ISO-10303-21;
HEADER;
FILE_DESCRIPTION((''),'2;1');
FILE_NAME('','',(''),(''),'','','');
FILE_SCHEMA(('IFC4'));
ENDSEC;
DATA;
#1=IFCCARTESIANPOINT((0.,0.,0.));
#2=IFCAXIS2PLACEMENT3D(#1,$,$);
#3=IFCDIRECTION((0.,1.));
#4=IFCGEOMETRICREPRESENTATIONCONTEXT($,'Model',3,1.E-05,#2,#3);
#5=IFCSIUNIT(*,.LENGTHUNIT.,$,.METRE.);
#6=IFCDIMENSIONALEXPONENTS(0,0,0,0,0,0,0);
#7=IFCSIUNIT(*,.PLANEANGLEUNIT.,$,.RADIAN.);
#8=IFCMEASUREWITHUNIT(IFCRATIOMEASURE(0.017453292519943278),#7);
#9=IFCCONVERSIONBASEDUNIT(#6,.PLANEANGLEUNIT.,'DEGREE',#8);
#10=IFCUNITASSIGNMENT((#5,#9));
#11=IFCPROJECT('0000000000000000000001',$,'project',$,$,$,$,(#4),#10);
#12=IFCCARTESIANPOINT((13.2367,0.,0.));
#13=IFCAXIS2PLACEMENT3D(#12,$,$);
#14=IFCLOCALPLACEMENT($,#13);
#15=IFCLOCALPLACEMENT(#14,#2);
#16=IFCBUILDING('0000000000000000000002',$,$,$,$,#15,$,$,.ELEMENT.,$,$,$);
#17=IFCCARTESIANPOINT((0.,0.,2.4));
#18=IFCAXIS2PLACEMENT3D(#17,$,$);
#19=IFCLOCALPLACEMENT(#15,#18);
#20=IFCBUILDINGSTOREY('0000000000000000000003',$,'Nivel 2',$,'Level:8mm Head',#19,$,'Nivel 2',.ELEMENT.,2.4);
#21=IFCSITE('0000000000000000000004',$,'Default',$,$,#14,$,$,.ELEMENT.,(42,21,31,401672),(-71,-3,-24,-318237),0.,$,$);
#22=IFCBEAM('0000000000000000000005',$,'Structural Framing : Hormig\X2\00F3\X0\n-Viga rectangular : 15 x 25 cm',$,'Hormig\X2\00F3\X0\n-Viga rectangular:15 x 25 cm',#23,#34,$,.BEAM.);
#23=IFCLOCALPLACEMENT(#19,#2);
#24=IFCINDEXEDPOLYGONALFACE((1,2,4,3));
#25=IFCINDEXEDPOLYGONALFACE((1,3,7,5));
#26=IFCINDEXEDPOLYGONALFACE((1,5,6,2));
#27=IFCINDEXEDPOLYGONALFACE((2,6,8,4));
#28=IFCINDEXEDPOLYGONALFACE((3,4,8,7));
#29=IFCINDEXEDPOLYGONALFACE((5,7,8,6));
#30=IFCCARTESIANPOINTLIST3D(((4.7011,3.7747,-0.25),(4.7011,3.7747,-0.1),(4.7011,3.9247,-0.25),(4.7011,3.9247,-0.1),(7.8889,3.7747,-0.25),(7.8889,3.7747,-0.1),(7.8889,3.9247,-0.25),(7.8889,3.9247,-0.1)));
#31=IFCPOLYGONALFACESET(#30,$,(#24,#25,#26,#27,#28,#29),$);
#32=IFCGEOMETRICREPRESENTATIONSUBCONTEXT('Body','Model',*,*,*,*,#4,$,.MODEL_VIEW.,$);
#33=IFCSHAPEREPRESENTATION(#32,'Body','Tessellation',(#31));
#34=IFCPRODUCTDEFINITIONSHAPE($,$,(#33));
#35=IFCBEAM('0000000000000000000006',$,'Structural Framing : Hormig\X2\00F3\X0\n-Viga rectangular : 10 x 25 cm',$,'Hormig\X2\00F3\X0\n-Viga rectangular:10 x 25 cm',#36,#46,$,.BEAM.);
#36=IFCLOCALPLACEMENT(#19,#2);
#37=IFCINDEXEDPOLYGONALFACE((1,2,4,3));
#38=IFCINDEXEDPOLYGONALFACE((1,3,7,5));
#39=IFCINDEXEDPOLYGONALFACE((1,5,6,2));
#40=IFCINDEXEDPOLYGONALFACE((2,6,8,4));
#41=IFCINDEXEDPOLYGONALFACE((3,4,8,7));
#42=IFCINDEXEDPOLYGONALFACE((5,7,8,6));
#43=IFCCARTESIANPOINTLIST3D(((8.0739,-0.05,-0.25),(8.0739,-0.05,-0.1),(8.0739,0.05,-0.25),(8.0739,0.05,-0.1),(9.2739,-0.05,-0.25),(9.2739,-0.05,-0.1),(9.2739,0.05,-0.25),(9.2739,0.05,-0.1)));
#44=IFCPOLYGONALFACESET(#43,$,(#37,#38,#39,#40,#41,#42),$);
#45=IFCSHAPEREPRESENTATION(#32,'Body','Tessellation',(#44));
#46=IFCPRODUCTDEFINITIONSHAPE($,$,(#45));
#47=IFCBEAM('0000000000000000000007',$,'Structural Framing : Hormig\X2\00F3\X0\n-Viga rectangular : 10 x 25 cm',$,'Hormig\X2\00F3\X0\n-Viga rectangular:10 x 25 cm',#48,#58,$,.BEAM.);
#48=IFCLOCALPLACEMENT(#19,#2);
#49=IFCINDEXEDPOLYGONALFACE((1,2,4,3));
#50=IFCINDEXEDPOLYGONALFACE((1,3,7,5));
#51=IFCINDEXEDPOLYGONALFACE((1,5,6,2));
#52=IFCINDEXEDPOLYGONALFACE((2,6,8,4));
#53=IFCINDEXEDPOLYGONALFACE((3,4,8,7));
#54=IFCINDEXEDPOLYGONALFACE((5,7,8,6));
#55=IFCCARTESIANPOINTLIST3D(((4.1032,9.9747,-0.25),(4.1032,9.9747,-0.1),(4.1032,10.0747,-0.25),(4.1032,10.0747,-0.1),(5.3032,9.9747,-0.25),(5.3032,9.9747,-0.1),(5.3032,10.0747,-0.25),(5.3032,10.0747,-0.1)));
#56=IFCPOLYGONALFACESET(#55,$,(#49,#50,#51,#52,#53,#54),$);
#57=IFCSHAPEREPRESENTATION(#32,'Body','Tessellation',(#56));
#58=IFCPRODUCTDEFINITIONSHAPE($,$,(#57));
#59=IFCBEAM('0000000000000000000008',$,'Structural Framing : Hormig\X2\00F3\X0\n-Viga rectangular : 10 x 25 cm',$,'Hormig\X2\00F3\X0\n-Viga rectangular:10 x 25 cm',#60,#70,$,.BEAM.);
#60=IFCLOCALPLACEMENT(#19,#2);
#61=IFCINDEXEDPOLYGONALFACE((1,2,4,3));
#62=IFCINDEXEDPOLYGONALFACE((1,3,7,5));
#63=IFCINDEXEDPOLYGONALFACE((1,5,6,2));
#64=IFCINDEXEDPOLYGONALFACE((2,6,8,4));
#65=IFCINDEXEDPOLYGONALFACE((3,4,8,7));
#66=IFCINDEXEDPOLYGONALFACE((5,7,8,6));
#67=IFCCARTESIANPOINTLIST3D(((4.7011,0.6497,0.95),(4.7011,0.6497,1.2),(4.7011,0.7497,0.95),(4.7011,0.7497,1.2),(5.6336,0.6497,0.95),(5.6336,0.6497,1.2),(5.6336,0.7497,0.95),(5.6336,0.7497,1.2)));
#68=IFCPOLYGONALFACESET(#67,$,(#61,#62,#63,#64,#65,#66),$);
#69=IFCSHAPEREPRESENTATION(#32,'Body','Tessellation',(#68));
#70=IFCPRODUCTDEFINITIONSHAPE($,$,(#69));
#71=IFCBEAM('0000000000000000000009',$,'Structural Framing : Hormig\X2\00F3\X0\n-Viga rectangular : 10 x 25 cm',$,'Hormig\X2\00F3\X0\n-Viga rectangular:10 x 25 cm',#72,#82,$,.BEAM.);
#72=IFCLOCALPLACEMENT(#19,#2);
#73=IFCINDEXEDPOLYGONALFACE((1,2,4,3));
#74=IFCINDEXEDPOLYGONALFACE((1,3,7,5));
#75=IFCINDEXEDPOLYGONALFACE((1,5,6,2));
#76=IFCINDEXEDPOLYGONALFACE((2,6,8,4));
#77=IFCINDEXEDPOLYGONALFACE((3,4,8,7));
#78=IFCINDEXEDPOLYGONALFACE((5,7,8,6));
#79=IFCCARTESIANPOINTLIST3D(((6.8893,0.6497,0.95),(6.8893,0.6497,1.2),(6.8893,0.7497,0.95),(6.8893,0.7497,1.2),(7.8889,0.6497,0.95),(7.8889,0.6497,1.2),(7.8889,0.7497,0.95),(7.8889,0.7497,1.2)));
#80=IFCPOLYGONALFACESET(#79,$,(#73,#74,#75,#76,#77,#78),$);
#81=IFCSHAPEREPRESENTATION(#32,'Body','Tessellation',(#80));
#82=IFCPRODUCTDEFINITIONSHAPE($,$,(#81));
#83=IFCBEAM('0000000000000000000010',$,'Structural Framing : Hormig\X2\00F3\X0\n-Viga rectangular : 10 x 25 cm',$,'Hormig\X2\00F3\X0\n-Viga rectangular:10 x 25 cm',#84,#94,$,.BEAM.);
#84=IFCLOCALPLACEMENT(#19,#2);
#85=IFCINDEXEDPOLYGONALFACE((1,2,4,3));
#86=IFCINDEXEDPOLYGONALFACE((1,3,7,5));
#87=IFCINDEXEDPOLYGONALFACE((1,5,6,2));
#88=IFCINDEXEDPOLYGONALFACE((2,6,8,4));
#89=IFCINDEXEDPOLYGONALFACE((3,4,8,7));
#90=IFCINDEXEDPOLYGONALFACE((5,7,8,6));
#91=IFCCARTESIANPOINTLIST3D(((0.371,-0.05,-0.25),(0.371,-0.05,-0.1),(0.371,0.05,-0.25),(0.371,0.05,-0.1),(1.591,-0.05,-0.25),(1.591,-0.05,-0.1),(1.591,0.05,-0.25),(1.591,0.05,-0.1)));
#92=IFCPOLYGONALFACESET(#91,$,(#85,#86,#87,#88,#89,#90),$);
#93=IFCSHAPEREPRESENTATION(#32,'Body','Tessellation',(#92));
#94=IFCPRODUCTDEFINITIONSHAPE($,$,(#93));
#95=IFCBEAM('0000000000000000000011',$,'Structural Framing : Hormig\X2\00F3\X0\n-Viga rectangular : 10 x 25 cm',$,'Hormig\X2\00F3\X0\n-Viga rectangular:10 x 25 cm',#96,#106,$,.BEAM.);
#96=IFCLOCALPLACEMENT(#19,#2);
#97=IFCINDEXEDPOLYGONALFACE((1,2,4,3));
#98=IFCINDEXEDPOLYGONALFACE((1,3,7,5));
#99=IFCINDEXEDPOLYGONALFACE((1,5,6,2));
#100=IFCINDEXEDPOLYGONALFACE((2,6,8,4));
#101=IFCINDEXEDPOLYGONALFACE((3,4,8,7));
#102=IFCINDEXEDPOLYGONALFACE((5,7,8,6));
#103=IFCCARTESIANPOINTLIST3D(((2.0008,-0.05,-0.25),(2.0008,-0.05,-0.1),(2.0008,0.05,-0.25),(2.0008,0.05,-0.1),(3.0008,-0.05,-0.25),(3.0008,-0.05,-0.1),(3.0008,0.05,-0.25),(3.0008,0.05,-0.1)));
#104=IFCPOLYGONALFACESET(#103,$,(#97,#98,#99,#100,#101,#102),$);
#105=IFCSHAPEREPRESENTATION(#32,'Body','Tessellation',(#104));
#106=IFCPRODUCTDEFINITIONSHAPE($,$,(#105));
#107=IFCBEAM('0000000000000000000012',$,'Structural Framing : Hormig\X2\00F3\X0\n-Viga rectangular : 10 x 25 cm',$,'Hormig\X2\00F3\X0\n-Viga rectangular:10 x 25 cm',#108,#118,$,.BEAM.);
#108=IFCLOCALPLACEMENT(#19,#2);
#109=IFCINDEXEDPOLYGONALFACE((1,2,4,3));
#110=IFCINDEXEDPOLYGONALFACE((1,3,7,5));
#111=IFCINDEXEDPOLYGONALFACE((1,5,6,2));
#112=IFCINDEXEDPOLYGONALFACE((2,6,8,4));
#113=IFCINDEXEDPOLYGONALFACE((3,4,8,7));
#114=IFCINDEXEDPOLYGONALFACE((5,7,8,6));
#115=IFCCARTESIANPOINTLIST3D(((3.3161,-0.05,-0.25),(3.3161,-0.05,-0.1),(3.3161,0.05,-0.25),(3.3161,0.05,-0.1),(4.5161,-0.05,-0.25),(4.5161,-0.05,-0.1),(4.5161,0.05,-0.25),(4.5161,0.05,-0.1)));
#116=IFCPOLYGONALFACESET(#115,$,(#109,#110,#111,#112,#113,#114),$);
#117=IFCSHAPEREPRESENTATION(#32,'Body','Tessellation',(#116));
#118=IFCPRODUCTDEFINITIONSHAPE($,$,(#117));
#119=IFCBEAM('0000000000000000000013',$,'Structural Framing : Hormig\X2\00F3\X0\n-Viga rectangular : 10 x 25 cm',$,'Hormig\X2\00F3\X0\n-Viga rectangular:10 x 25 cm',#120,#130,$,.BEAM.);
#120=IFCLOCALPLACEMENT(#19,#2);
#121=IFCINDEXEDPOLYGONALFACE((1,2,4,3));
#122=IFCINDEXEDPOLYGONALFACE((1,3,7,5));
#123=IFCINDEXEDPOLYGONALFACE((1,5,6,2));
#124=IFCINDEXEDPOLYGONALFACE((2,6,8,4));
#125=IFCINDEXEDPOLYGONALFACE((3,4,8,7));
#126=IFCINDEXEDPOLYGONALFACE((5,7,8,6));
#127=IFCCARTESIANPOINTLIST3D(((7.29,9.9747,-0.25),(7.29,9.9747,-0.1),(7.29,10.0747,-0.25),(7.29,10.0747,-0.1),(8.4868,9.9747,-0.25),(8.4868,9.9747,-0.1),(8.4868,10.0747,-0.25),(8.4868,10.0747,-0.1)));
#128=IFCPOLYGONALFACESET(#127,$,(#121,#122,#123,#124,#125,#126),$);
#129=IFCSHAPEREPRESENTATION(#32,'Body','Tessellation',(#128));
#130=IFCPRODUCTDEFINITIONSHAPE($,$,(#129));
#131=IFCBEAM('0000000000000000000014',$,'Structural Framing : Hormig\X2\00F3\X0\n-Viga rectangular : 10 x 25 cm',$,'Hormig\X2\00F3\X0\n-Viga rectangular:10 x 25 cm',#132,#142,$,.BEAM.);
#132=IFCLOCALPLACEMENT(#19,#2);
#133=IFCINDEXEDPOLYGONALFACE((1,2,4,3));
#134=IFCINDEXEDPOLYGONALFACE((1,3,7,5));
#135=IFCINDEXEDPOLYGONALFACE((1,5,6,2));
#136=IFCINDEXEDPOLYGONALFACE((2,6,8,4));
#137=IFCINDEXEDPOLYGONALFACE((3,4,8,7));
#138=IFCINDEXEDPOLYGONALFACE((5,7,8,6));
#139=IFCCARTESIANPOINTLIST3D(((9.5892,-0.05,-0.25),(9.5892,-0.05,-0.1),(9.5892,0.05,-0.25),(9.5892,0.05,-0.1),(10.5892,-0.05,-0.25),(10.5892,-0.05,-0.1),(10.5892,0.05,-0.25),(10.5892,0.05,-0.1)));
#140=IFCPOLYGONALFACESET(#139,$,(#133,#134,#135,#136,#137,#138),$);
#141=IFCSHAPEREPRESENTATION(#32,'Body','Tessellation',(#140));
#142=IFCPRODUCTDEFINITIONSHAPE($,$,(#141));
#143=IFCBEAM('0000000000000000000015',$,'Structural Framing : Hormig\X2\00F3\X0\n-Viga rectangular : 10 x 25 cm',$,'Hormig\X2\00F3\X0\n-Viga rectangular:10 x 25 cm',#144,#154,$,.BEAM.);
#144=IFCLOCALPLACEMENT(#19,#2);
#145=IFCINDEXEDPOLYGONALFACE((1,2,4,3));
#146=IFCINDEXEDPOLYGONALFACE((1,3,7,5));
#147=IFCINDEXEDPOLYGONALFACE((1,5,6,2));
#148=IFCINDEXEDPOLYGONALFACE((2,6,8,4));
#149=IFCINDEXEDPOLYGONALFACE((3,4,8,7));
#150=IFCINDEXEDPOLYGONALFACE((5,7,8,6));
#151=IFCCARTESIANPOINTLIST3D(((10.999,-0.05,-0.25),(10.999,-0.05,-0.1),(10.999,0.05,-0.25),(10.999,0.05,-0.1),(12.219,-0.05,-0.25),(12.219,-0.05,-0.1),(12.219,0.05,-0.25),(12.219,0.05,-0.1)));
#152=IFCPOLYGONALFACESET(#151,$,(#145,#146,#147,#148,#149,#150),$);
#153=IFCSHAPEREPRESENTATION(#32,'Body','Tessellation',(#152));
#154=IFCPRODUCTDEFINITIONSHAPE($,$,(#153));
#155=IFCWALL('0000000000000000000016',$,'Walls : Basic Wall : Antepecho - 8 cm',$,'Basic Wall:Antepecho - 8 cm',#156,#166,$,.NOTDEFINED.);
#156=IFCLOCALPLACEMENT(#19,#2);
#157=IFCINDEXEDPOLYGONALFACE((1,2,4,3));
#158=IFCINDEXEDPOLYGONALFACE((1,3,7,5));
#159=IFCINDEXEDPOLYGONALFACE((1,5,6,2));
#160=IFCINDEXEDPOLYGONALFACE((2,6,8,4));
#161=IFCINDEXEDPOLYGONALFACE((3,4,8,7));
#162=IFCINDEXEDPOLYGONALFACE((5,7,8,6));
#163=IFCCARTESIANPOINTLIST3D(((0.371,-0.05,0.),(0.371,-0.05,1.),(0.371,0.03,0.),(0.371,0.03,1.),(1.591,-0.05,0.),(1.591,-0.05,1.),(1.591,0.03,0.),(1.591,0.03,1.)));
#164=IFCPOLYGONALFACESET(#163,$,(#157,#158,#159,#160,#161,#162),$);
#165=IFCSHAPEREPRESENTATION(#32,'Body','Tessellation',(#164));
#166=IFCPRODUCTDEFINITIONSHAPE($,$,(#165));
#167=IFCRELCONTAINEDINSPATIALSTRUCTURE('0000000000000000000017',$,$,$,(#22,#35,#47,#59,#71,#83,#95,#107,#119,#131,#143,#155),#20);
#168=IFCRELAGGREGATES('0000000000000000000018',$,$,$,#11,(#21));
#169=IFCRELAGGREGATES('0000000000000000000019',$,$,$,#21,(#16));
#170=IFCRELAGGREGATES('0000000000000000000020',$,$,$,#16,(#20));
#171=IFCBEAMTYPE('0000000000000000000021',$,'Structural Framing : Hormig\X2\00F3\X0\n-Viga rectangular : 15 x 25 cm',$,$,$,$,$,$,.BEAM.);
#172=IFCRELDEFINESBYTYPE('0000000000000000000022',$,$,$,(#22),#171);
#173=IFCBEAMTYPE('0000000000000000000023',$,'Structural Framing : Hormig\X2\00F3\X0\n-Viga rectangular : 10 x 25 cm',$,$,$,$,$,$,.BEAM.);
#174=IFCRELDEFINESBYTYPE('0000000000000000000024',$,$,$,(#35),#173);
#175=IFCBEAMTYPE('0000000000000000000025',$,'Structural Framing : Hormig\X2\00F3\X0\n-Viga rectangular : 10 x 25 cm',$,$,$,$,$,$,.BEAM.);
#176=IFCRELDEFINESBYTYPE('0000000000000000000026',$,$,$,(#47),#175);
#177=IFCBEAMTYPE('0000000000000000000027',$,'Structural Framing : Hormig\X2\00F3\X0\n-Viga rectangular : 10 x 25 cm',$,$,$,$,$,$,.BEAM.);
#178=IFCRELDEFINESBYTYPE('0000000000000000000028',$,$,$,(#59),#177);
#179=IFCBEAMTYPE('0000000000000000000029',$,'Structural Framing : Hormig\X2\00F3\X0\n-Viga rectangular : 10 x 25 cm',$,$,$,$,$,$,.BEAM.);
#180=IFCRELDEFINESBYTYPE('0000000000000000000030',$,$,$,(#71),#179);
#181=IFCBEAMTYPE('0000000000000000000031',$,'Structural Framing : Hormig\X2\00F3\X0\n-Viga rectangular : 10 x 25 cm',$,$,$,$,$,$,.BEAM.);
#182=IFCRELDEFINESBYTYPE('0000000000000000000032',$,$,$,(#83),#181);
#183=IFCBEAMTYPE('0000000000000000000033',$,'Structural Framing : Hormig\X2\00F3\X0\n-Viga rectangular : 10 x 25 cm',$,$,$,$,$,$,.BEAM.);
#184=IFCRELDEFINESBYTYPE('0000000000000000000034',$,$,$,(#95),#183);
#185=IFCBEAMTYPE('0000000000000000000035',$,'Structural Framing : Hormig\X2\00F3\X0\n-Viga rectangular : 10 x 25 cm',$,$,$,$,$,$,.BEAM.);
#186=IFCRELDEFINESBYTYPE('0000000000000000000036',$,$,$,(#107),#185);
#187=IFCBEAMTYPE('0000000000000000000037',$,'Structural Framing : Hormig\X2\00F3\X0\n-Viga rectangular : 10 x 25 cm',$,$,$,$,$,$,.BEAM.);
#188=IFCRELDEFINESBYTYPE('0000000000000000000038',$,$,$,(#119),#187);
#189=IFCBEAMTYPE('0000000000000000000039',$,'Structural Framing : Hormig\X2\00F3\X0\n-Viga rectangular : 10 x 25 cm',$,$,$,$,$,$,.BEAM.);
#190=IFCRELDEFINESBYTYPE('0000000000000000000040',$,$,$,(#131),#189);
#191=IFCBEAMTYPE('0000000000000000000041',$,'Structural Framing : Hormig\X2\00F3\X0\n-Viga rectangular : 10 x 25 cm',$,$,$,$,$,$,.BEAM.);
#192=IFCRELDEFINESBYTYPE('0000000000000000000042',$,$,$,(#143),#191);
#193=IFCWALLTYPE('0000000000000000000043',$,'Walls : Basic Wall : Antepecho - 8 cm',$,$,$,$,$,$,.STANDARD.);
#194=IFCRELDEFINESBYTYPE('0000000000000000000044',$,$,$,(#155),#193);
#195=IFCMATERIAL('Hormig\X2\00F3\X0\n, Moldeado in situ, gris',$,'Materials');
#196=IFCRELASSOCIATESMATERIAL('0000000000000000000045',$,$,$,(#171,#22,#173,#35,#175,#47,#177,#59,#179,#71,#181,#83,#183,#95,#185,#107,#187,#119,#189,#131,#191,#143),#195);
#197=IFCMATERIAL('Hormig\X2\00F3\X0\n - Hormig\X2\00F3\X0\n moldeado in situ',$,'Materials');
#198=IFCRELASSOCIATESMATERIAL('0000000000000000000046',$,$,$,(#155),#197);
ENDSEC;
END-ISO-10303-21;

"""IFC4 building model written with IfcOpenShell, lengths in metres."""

from ifc_helpers import new_model, entity, si_unit, converted_unit, direction, frame, origin, place, context, subcontext, project, spatial, indexed_curve, outline, extrude, source, transform, mapped, material, type_object, type_shapes, element, save


model = new_model("IFC4")

# Units and contexts
model_context = context("Model", 3, precision=1e-05, world=origin(), true_north=direction((0.0, 1.0)))
body_context = subcontext(model_context, "Body", "Model", "MODEL_VIEW")
ifc_project = project(units=[si_unit("LENGTHUNIT", "METRE"), converted_unit("PLANEANGLEUNIT", "DEGREE", entity("IfcRatioMeasure", 0.017453292519943278), si_unit("PLANEANGLEUNIT", "RADIAN"), dimensions=[0, 0, 0, 0, 0, 0, 0])], contexts=[model_context])

# Site, building, storey
site_placement = place(None, frame((13.2367, 0.0, 0.0)))
site = spatial("IfcSite", under=ifc_project, at=site_placement, Name="Default", CompositionType="ELEMENT", RefLatitude=(42, 21, 31, 401672), RefLongitude=(-71, -3, -24, -318237), RefElevation=0.0)
building_placement = place(site_placement, origin())
building = spatial("IfcBuilding", under=site, at=building_placement, CompositionType="ELEMENT")
storey_placement = place(building_placement, frame((0.0, 0.0, 2.4)))
storey = spatial("IfcBuildingStorey", under=building, at=storey_placement, Name="Nivel 2", ObjectType="Level:8mm Head", LongName="Nivel 2", CompositionType="ELEMENT", Elevation=2.4)

# Beams
ifc_material_1 = material(Name="Hormigón, Moldeado in situ, gris", Category="Materials")
beam_type_1 = type_object("IfcBeamType", Name="Structural Framing : Hormigón-Viga rectangular : 15 x 25 cm", PredefinedType="BEAM", material=ifc_material_1)
shared_shape_1 = source(origin(), body_context, "Body", "SweptSolid", [
    extrude(outline(indexed_curve([(-0.075, -0.075), (0.075, -0.075), (0.075, 0.075), (-0.075, 0.075), (-0.075, -0.075)], self_intersect=False)), frame((4.7011, 3.8497, 2.225), z_axis=(1.0, 0.0, 0.0), x_axis=(0.0, 0.0, -1.0)), (0.0, 0.0, 1.0), 3.1878),
])
type_shapes(beam_type_1, [shared_shape_1])
beam_1_placement = place(storey_placement, frame((0.0, 0.0, -2.4)))
element("IfcBeam", 1, at=beam_1_placement, inside=storey, type_object=beam_type_1, material=ifc_material_1, Name="Structural Framing : Hormigón-Viga rectangular : 15 x 25 cm", ObjectType="Hormigón-Viga rectangular:15 x 25 cm", PredefinedType="BEAM", context=body_context, shape_type="MappedRepresentation", body=[
    mapped(shared_shape_1, transform((0.0, 0.0, 0.0), scale=1.0)),
])
beam_type_2 = type_object("IfcBeamType", Name="Structural Framing : Hormigón-Viga rectangular : 10 x 25 cm", PredefinedType="BEAM", material=ifc_material_1)
shared_shape_2 = source(origin(), body_context, "Body", "SweptSolid", [
    extrude(outline(indexed_curve([(-0.075, -0.05), (0.075, -0.05), (0.075, 0.05), (-0.075, 0.05), (-0.075, -0.05)], self_intersect=False)), frame((8.0739, 0.0, 2.225), z_axis=(1.0, 0.0, 0.0), x_axis=(0.0, 0.0, -1.0)), (0.0, 0.0, 1.0), 1.2),
])
type_shapes(beam_type_2, [shared_shape_2])
beam_2_placement = place(storey_placement, frame((0.0, 0.0, -2.4)))
element("IfcBeam", 2, at=beam_2_placement, inside=storey, type_object=beam_type_2, material=ifc_material_1, Name="Structural Framing : Hormigón-Viga rectangular : 10 x 25 cm", ObjectType="Hormigón-Viga rectangular:10 x 25 cm", PredefinedType="BEAM", context=body_context, shape_type="MappedRepresentation", body=[
    mapped(shared_shape_2, transform((0.0, 0.0, 0.0), scale=1.0)),
])
beam_type_3 = type_object("IfcBeamType", Name="Structural Framing : Hormigón-Viga rectangular : 10 x 25 cm", PredefinedType="BEAM", material=ifc_material_1)
shared_shape_3 = source(origin(), body_context, "Body", "SweptSolid", [
    extrude(outline(indexed_curve([(-0.075, -0.05), (0.075, -0.05), (0.075, 0.05), (-0.075, 0.05), (-0.075, -0.05)], self_intersect=False)), frame((5.3032, 10.0247, 2.225), z_axis=(-1.0, 0.0, 0.0), x_axis=(0.0, 0.0, -1.0)), (0.0, 0.0, 1.0), 1.2),
])
type_shapes(beam_type_3, [shared_shape_3])
beam_3_placement = place(storey_placement, frame((0.0, 0.0, -2.4)))
element("IfcBeam", 3, at=beam_3_placement, inside=storey, type_object=beam_type_3, material=ifc_material_1, Name="Structural Framing : Hormigón-Viga rectangular : 10 x 25 cm", ObjectType="Hormigón-Viga rectangular:10 x 25 cm", PredefinedType="BEAM", context=body_context, shape_type="MappedRepresentation", body=[
    mapped(shared_shape_3, transform((0.0, 0.0, 0.0), scale=1.0)),
])
beam_type_4 = type_object("IfcBeamType", Name="Structural Framing : Hormigón-Viga rectangular : 10 x 25 cm", PredefinedType="BEAM", material=ifc_material_1)
shared_shape_4 = source(origin(), body_context, "Body", "SweptSolid", [
    extrude(outline(indexed_curve([(-0.125, -0.05), (0.125, -0.05), (0.125, 0.05), (-0.125, 0.05), (-0.125, -0.05)], self_intersect=False)), frame((5.6336, 0.6997, 3.475), z_axis=(-1.0, 0.0, 0.0), x_axis=(0.0, 0.0, -1.0)), (0.0, 0.0, 1.0), 0.9325),
])
type_shapes(beam_type_4, [shared_shape_4])
beam_4_placement = place(storey_placement, frame((0.0, 0.0, -2.4)))
element("IfcBeam", 4, at=beam_4_placement, inside=storey, type_object=beam_type_4, material=ifc_material_1, Name="Structural Framing : Hormigón-Viga rectangular : 10 x 25 cm", ObjectType="Hormigón-Viga rectangular:10 x 25 cm", PredefinedType="BEAM", context=body_context, shape_type="MappedRepresentation", body=[
    mapped(shared_shape_4, transform((0.0, 0.0, 0.0), scale=1.0)),
])
beam_type_5 = type_object("IfcBeamType", Name="Structural Framing : Hormigón-Viga rectangular : 10 x 25 cm", PredefinedType="BEAM", material=ifc_material_1)
shared_shape_5 = source(origin(), body_context, "Body", "SweptSolid", [
    extrude(outline(indexed_curve([(-0.125, -0.05), (0.125, -0.05), (0.125, 0.05), (-0.125, 0.05), (-0.125, -0.05)], self_intersect=False)), frame((7.8889, 0.6997, 3.475), z_axis=(-1.0, 0.0, 0.0), x_axis=(0.0, 0.0, -1.0)), (0.0, 0.0, 1.0), 0.9996),
])
type_shapes(beam_type_5, [shared_shape_5])
beam_5_placement = place(storey_placement, frame((0.0, 0.0, -2.4)))
element("IfcBeam", 5, at=beam_5_placement, inside=storey, type_object=beam_type_5, material=ifc_material_1, Name="Structural Framing : Hormigón-Viga rectangular : 10 x 25 cm", ObjectType="Hormigón-Viga rectangular:10 x 25 cm", PredefinedType="BEAM", context=body_context, shape_type="MappedRepresentation", body=[
    mapped(shared_shape_5, transform((0.0, 0.0, 0.0), scale=1.0)),
])
beam_type_6 = type_object("IfcBeamType", Name="Structural Framing : Hormigón-Viga rectangular : 10 x 25 cm", PredefinedType="BEAM", material=ifc_material_1)
shared_shape_6 = source(origin(), body_context, "Body", "SweptSolid", [
    extrude(outline(indexed_curve([(-0.075, -0.05), (0.075, -0.05), (0.075, 0.05), (-0.075, 0.05), (-0.075, -0.05)], self_intersect=False)), frame((0.371, 0.0, 2.225), z_axis=(1.0, 0.0, 0.0), x_axis=(0.0, 0.0, -1.0)), (0.0, 0.0, 1.0), 1.22),
])
type_shapes(beam_type_6, [shared_shape_6])
beam_6_placement = place(storey_placement, frame((0.0, 0.0, -2.4)))
element("IfcBeam", 6, at=beam_6_placement, inside=storey, type_object=beam_type_6, material=ifc_material_1, Name="Structural Framing : Hormigón-Viga rectangular : 10 x 25 cm", ObjectType="Hormigón-Viga rectangular:10 x 25 cm", PredefinedType="BEAM", context=body_context, shape_type="MappedRepresentation", body=[
    mapped(shared_shape_6, transform((0.0, 0.0, 0.0), scale=1.0)),
])
beam_type_7 = type_object("IfcBeamType", Name="Structural Framing : Hormigón-Viga rectangular : 10 x 25 cm", PredefinedType="BEAM", material=ifc_material_1)
shared_shape_7 = source(origin(), body_context, "Body", "SweptSolid", [
    extrude(outline(indexed_curve([(-0.075, -0.05), (0.075, -0.05), (0.075, 0.05), (-0.075, 0.05), (-0.075, -0.05)], self_intersect=False)), frame((2.0008, 0.0, 2.225), z_axis=(1.0, 0.0, 0.0), x_axis=(0.0, 0.0, -1.0)), (0.0, 0.0, 1.0), 1.0),
])
type_shapes(beam_type_7, [shared_shape_7])
beam_7_placement = place(storey_placement, frame((0.0, 0.0, -2.4)))
element("IfcBeam", 7, at=beam_7_placement, inside=storey, type_object=beam_type_7, material=ifc_material_1, Name="Structural Framing : Hormigón-Viga rectangular : 10 x 25 cm", ObjectType="Hormigón-Viga rectangular:10 x 25 cm", PredefinedType="BEAM", context=body_context, shape_type="MappedRepresentation", body=[
    mapped(shared_shape_7, transform((0.0, 0.0, 0.0), scale=1.0)),
])
beam_type_8 = type_object("IfcBeamType", Name="Structural Framing : Hormigón-Viga rectangular : 10 x 25 cm", PredefinedType="BEAM", material=ifc_material_1)
shared_shape_8 = source(origin(), body_context, "Body", "SweptSolid", [
    extrude(outline(indexed_curve([(-0.075, -0.05), (0.075, -0.05), (0.075, 0.05), (-0.075, 0.05), (-0.075, -0.05)], self_intersect=False)), frame((3.3161, 0.0, 2.225), z_axis=(1.0, 0.0, 0.0), x_axis=(0.0, 0.0, -1.0)), (0.0, 0.0, 1.0), 1.2),
])
type_shapes(beam_type_8, [shared_shape_8])
beam_8_placement = place(storey_placement, frame((0.0, 0.0, -2.4)))
element("IfcBeam", 8, at=beam_8_placement, inside=storey, type_object=beam_type_8, material=ifc_material_1, Name="Structural Framing : Hormigón-Viga rectangular : 10 x 25 cm", ObjectType="Hormigón-Viga rectangular:10 x 25 cm", PredefinedType="BEAM", context=body_context, shape_type="MappedRepresentation", body=[
    mapped(shared_shape_8, transform((0.0, 0.0, 0.0), scale=1.0)),
])
beam_type_9 = type_object("IfcBeamType", Name="Structural Framing : Hormigón-Viga rectangular : 10 x 25 cm", PredefinedType="BEAM", material=ifc_material_1)
shared_shape_9 = source(origin(), body_context, "Body", "SweptSolid", [
    extrude(outline(indexed_curve([(-0.075, -0.05), (0.075, -0.05), (0.075, 0.05), (-0.075, 0.05), (-0.075, -0.05)], self_intersect=False)), frame((7.29, 10.0247, 2.225), z_axis=(1.0, 0.0, 0.0), x_axis=(0.0, 0.0, -1.0)), (0.0, 0.0, 1.0), 1.1968),
])
type_shapes(beam_type_9, [shared_shape_9])
beam_9_placement = place(storey_placement, frame((0.0, 0.0, -2.4)))
element("IfcBeam", 9, at=beam_9_placement, inside=storey, type_object=beam_type_9, material=ifc_material_1, Name="Structural Framing : Hormigón-Viga rectangular : 10 x 25 cm", ObjectType="Hormigón-Viga rectangular:10 x 25 cm", PredefinedType="BEAM", context=body_context, shape_type="MappedRepresentation", body=[
    mapped(shared_shape_9, transform((0.0, 0.0, 0.0), scale=1.0)),
])
beam_type_10 = type_object("IfcBeamType", Name="Structural Framing : Hormigón-Viga rectangular : 10 x 25 cm", PredefinedType="BEAM", material=ifc_material_1)
shared_shape_10 = source(origin(), body_context, "Body", "SweptSolid", [
    extrude(outline(indexed_curve([(-0.075, -0.05), (0.075, -0.05), (0.075, 0.05), (-0.075, 0.05), (-0.075, -0.05)], self_intersect=False)), frame((9.5892, 0.0, 2.225), z_axis=(1.0, 0.0, 0.0), x_axis=(0.0, 0.0, -1.0)), (0.0, 0.0, 1.0), 1.0),
])
type_shapes(beam_type_10, [shared_shape_10])
beam_10_placement = place(storey_placement, frame((0.0, 0.0, -2.4)))
element("IfcBeam", 10, at=beam_10_placement, inside=storey, type_object=beam_type_10, material=ifc_material_1, Name="Structural Framing : Hormigón-Viga rectangular : 10 x 25 cm", ObjectType="Hormigón-Viga rectangular:10 x 25 cm", PredefinedType="BEAM", context=body_context, shape_type="MappedRepresentation", body=[
    mapped(shared_shape_10, transform((0.0, 0.0, 0.0), scale=1.0)),
])
beam_type_11 = type_object("IfcBeamType", Name="Structural Framing : Hormigón-Viga rectangular : 10 x 25 cm", PredefinedType="BEAM", material=ifc_material_1)
shared_shape_11 = source(origin(), body_context, "Body", "SweptSolid", [
    extrude(outline(indexed_curve([(-0.075, -0.05), (0.075, -0.05), (0.075, 0.05), (-0.075, 0.05), (-0.075, -0.05)], self_intersect=False)), frame((12.219, 0.0, 2.225), z_axis=(-1.0, 0.0, 0.0), x_axis=(0.0, 0.0, -1.0)), (0.0, 0.0, 1.0), 1.22),
])
type_shapes(beam_type_11, [shared_shape_11])
beam_11_placement = place(storey_placement, frame((0.0, 0.0, -2.4)))
element("IfcBeam", 11, at=beam_11_placement, inside=storey, type_object=beam_type_11, material=ifc_material_1, Name="Structural Framing : Hormigón-Viga rectangular : 10 x 25 cm", ObjectType="Hormigón-Viga rectangular:10 x 25 cm", PredefinedType="BEAM", context=body_context, shape_type="MappedRepresentation", body=[
    mapped(shared_shape_11, transform((0.0, 0.0, 0.0), scale=1.0)),
])

# Shared definitions
ifc_material_2 = material(Name="Hormigón - Hormigón moldeado in situ", Category="Materials")

# Wall
wall_type = type_object("IfcWallType", Name="Walls : Basic Wall : Antepecho - 8 cm", PredefinedType="STANDARD")
wall_1_placement = place(storey_placement, frame((0.371, -0.01, 0.0)))
element("IfcWall", 12, at=wall_1_placement, inside=storey, type_object=wall_type, material=ifc_material_2, Name="Walls : Basic Wall : Antepecho - 8 cm", ObjectType="Basic Wall:Antepecho - 8 cm", PredefinedType="NOTDEFINED", context=body_context, shape_type="SweptSolid", body=[
    extrude(outline(indexed_curve([(1.22, 0.04), (0.0, 0.04), (0.0, -0.04), (1.22, -0.04), (1.22, 0.04)], self_intersect=False)), origin(), (0.0, 0.0, 1.0), 1.0),
])

save(model, "model.ifc")
